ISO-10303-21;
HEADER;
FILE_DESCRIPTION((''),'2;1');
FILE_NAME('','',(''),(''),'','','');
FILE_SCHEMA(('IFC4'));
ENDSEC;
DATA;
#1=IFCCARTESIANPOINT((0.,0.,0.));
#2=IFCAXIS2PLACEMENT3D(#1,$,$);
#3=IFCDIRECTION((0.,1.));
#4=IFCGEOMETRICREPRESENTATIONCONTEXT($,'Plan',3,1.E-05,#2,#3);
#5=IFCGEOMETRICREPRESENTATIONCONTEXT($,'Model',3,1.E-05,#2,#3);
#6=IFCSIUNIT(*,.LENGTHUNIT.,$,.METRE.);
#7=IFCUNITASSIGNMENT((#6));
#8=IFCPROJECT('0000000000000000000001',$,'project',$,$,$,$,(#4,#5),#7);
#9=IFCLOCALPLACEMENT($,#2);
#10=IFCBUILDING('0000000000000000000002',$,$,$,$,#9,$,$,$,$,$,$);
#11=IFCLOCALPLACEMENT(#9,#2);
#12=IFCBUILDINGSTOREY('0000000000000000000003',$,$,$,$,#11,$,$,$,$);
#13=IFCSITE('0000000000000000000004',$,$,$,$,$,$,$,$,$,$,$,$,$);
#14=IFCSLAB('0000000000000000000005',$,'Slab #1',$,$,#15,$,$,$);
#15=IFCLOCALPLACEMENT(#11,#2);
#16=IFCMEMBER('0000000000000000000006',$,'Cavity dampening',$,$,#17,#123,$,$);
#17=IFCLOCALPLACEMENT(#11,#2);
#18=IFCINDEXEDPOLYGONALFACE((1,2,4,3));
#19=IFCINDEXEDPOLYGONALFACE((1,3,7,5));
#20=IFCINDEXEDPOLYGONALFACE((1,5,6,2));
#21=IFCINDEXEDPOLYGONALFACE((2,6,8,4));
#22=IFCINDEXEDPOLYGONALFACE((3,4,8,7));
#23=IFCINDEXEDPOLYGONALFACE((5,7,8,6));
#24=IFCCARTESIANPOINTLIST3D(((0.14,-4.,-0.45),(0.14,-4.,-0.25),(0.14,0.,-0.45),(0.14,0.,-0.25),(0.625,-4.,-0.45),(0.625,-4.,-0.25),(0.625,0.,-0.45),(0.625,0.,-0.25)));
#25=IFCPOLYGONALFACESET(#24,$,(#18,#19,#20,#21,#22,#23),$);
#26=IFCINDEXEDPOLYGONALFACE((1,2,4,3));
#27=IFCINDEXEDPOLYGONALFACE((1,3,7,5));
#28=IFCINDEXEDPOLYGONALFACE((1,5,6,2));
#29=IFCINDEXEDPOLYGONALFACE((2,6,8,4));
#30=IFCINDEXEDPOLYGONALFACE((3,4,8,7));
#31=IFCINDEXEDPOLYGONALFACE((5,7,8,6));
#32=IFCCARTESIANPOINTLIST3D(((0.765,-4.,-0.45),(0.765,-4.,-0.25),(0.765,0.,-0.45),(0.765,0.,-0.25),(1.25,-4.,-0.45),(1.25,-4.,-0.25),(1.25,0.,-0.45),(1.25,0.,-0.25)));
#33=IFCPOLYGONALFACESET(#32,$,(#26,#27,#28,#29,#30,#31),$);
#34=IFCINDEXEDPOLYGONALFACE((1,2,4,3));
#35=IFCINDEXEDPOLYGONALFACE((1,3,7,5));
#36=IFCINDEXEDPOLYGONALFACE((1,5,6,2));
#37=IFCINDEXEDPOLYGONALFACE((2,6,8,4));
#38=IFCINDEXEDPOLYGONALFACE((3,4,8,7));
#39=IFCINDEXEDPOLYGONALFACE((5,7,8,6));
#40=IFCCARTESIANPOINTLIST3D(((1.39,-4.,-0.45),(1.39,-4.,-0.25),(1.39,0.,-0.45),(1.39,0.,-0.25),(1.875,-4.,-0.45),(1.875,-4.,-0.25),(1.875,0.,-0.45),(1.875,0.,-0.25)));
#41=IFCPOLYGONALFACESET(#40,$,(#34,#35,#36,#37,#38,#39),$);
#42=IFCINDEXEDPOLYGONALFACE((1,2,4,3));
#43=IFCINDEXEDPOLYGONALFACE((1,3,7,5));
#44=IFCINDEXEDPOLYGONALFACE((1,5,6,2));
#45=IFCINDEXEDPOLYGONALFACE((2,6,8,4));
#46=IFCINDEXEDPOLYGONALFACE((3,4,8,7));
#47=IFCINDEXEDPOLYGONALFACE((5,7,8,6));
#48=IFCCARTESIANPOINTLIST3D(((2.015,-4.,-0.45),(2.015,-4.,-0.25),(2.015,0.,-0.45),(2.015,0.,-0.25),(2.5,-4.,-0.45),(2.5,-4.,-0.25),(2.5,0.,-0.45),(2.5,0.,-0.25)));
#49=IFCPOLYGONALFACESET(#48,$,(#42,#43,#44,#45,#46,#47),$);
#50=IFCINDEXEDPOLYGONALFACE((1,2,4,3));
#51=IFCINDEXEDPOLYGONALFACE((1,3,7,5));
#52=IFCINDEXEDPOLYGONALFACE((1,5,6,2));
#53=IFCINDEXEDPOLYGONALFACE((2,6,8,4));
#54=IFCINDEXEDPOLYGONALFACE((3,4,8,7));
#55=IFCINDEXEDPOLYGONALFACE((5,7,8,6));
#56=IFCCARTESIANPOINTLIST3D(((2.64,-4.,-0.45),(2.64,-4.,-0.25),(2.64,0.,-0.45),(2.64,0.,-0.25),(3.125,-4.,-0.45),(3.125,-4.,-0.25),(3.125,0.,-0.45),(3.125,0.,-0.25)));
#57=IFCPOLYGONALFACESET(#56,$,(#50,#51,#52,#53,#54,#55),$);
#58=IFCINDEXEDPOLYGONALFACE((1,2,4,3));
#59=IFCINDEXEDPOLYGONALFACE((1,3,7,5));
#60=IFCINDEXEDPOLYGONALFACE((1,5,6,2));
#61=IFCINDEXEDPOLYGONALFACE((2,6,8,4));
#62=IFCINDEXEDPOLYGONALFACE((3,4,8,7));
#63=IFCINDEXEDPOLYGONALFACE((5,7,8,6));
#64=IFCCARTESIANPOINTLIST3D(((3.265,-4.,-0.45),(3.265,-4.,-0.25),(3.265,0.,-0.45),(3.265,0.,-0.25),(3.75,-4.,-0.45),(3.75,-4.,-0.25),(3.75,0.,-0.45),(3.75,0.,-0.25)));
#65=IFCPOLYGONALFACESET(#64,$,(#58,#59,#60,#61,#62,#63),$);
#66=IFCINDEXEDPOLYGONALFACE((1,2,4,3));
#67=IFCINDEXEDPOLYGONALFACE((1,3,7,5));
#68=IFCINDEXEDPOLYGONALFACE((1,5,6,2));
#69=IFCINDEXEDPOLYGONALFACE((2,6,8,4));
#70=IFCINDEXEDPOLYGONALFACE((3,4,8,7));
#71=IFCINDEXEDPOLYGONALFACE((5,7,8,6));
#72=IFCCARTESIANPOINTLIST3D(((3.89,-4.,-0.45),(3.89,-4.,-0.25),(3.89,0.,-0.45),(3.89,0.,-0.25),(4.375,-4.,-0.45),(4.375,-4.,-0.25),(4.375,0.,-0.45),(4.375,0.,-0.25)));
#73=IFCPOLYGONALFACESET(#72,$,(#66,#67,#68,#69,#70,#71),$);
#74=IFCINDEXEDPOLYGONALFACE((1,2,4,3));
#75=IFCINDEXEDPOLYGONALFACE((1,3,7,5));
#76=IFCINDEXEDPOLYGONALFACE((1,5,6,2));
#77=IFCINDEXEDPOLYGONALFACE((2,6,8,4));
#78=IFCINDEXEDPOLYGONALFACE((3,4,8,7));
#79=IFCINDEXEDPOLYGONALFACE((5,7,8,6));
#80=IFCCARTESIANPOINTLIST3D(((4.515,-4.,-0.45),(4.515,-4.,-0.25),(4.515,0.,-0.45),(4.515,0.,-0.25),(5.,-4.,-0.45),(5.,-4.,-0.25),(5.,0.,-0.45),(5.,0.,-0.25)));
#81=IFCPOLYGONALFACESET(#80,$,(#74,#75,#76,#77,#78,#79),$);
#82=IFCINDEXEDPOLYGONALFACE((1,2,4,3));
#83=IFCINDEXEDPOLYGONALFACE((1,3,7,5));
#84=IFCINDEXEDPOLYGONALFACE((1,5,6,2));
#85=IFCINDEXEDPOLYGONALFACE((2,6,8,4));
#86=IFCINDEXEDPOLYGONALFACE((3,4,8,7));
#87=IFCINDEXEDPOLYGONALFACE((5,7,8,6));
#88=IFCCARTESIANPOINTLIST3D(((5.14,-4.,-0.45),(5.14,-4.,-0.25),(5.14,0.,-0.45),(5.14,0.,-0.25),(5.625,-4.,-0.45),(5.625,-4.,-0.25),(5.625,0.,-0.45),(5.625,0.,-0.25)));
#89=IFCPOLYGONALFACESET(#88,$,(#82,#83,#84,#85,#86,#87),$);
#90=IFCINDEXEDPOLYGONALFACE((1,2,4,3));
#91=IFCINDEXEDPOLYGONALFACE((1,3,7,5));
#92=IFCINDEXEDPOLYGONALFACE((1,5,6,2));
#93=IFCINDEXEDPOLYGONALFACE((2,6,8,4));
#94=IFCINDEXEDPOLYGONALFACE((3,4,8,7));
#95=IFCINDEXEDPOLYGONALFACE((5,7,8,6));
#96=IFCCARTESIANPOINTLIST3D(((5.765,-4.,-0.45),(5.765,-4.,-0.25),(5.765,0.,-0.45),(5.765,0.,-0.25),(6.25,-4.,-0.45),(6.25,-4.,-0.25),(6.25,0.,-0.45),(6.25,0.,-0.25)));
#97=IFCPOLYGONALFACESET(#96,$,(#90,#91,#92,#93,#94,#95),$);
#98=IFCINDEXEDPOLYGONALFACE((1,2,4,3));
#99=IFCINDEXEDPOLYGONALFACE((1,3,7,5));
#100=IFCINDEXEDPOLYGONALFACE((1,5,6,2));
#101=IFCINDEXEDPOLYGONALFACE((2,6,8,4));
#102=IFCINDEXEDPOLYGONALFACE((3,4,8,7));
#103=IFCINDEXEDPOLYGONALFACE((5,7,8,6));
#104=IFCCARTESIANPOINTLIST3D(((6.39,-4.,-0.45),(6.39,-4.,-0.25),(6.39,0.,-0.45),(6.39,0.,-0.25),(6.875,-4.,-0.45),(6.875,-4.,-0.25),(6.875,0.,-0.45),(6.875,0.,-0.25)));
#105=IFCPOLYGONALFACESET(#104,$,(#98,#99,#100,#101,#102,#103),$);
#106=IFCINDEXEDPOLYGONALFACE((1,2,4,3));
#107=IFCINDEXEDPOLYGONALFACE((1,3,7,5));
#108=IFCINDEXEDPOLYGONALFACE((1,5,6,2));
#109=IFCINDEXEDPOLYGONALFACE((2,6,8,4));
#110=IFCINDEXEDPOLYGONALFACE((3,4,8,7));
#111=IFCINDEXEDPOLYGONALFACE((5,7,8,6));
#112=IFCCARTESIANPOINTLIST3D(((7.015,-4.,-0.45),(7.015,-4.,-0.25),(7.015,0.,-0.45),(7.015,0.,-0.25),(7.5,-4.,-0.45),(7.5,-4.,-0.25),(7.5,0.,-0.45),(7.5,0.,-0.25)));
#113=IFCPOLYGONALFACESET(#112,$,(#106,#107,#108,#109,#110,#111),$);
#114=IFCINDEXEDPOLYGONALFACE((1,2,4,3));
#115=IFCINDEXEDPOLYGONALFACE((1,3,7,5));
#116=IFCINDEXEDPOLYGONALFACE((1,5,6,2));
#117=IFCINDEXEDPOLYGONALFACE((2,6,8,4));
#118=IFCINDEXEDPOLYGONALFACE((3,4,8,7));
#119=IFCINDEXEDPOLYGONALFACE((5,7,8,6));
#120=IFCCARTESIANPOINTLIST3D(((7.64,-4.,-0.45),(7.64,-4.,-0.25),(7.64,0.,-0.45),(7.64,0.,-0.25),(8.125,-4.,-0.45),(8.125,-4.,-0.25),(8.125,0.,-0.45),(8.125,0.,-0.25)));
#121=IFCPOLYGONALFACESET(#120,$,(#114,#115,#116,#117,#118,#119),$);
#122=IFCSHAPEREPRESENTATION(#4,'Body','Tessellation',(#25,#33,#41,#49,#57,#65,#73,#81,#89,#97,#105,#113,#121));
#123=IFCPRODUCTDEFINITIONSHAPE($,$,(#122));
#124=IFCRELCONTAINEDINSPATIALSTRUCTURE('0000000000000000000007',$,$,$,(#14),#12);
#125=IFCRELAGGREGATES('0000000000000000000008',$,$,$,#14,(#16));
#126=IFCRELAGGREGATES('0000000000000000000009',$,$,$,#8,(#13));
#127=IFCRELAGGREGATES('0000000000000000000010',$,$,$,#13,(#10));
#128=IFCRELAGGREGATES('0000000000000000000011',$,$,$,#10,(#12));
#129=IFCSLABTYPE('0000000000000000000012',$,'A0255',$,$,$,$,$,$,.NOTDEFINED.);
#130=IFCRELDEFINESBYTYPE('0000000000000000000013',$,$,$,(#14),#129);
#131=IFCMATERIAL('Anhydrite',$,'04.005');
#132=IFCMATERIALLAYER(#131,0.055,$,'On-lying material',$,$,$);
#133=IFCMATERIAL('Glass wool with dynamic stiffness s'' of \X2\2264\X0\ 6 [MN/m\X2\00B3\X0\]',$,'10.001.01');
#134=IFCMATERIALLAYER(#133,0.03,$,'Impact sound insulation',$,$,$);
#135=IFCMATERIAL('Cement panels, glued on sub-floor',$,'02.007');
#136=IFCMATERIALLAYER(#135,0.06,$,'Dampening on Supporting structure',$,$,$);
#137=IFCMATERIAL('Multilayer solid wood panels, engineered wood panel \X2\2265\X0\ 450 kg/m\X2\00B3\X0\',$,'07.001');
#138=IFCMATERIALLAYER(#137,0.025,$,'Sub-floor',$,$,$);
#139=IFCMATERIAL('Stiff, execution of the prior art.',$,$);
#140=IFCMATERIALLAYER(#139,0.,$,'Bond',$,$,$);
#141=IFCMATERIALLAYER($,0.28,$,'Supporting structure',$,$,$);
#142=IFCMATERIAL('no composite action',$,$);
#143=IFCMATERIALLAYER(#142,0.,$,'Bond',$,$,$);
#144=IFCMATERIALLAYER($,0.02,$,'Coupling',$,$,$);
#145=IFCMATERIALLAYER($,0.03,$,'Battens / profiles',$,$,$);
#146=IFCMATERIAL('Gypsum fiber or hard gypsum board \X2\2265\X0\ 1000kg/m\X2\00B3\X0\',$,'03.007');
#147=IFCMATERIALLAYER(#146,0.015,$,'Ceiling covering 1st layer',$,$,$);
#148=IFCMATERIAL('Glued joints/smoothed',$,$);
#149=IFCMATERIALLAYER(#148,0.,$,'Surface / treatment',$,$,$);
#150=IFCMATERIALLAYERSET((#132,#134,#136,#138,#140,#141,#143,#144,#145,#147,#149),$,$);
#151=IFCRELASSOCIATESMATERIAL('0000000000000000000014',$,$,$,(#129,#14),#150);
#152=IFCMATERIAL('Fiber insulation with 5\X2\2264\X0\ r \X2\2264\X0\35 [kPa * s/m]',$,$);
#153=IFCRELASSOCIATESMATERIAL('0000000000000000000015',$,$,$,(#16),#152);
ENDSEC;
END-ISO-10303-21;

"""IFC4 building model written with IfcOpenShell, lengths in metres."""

from ifc_helpers import new_model, si_unit, direction, frame, frame_2d, origin, place, context, project, spatial, rectangle, extrude, material, layer, layer_set, type_object, element, aggregate, save


model = new_model("IFC4")

# Units and contexts
plan_context = context("Plan", 3, precision=1e-05, world=origin(), true_north=direction((0.0, 1.0)))
model_context = context("Model", 3, precision=1e-05, world=origin(), true_north=direction((0.0, 1.0)))
ifc_project = project(units=[si_unit("LENGTHUNIT", "METRE")], contexts=[plan_context, model_context])

# Site, building, storey
site = spatial("IfcSite", under=ifc_project)
building_placement = place(None, origin())
building = spatial("IfcBuilding", under=site, at=building_placement)
storey_placement = place(building_placement, origin())
storey = spatial("IfcBuildingStorey", under=building, at=storey_placement)

# Slab, member
ifc_material_1 = material(Name="Anhydrite", Category="04.005")
ifc_layer_1 = layer(ifc_material_1, 0.055, Name="On-lying material")
ifc_material_2 = material(Name="Glass wool with dynamic stiffness s' of ≤ 6 [MN/m³]", Category="10.001.01")
ifc_layer_2 = layer(ifc_material_2, 0.03, Name="Impact sound insulation")
ifc_material_3 = material(Name="Cement panels, glued on sub-floor", Category="02.007")
ifc_layer_3 = layer(ifc_material_3, 0.06, Name="Dampening on Supporting structure")
ifc_material_4 = material(Name="Multilayer solid wood panels, engineered wood panel ≥ 450 kg/m³", Category="07.001")
ifc_layer_4 = layer(ifc_material_4, 0.025, Name="Sub-floor")
ifc_material_5 = material(Name="Stiff, execution of the prior art.")
ifc_layer_5 = layer(ifc_material_5, 0.0, Name="Bond")
ifc_layer_6 = layer(None, 0.28, Name="Supporting structure")
ifc_material_6 = material(Name="no composite action")
ifc_layer_7 = layer(ifc_material_6, 0.0, Name="Bond")
ifc_layer_8 = layer(None, 0.02, Name="Coupling")
ifc_layer_9 = layer(None, 0.03, Name="Battens / profiles")
ifc_material_7 = material(Name="Gypsum fiber or hard gypsum board ≥ 1000kg/m³", Category="03.007")
ifc_layer_10 = layer(ifc_material_7, 0.015, Name="Ceiling covering 1st layer")
ifc_material_8 = material(Name="Glued joints/smoothed")
ifc_layer_11 = layer(ifc_material_8, 0.0, Name="Surface / treatment")
ifc_layer_set = layer_set([ifc_layer_1, ifc_layer_2, ifc_layer_3, ifc_layer_4, ifc_layer_5, ifc_layer_6, ifc_layer_7, ifc_layer_8, ifc_layer_9, ifc_layer_10, ifc_layer_11])
slab_type = type_object("IfcSlabType", Name="A0255", PredefinedType="NOTDEFINED", material=ifc_layer_set)
slab_placement = place(None, frame((0.0, 0.0, 0.0), z_axis=(0.0, 0.0, -1.0), x_axis=(1.0, 0.0, 0.0)))
slab = element("IfcSlab", 1, at=slab_placement, inside=storey, type_object=slab_type, material=ifc_layer_set, Name="Slab #1")
ifc_material_9 = material(Name="Fiber insulation with 5≤ r ≤35 [kPa * s/m]")
member_1_placement = place(slab_placement, origin())
member_1 = element("IfcMember", 2, at=member_1_placement, material=ifc_material_9, Name="Cavity dampening", context=plan_context, shape_type="SweptSolid", body=[
    extrude(rectangle(XDim=0.485, YDim=0.2, at=frame_2d((0.2425, 0.1), x_axis=(1.0, 0.0))), frame((0.14, 4.0, 0.25), z_axis=(0.0, -1.0, 0.0), x_axis=(1.0, 0.0, 0.0)), (0.0, 0.0, 1.0), 4.0),
    extrude(rectangle(XDim=0.485, YDim=0.2, at=frame_2d((0.2425, 0.1), x_axis=(1.0, 0.0))), frame((0.765, 4.0, 0.25), z_axis=(0.0, -1.0, 0.0), x_axis=(1.0, 0.0, 0.0)), (0.0, 0.0, 1.0), 4.0),
    extrude(rectangle(XDim=0.485, YDim=0.2, at=frame_2d((0.2425, 0.1), x_axis=(1.0, 0.0))), frame((1.39, 4.0, 0.25), z_axis=(0.0, -1.0, 0.0), x_axis=(1.0, 0.0, 0.0)), (0.0, 0.0, 1.0), 4.0),
    extrude(rectangle(XDim=0.485, YDim=0.2, at=frame_2d((0.2425, 0.1), x_axis=(1.0, 0.0))), frame((2.015, 4.0, 0.25), z_axis=(0.0, -1.0, 0.0), x_axis=(1.0, 0.0, 0.0)), (0.0, 0.0, 1.0), 4.0),
    extrude(rectangle(XDim=0.485, YDim=0.2, at=frame_2d((0.2425, 0.1), x_axis=(1.0, 0.0))), frame((2.64, 4.0, 0.25), z_axis=(0.0, -1.0, 0.0), x_axis=(1.0, 0.0, 0.0)), (0.0, 0.0, 1.0), 4.0),
    extrude(rectangle(XDim=0.485, YDim=0.2, at=frame_2d((0.2425, 0.1), x_axis=(1.0, 0.0))), frame((3.265, 4.0, 0.25), z_axis=(0.0, -1.0, 0.0), x_axis=(1.0, 0.0, 0.0)), (0.0, 0.0, 1.0), 4.0),
    extrude(rectangle(XDim=0.485, YDim=0.2, at=frame_2d((0.2425, 0.1), x_axis=(1.0, 0.0))), frame((3.89, 4.0, 0.25), z_axis=(0.0, -1.0, 0.0), x_axis=(1.0, 0.0, 0.0)), (0.0, 0.0, 1.0), 4.0),
    extrude(rectangle(XDim=0.485, YDim=0.2, at=frame_2d((0.2425, 0.1), x_axis=(1.0, 0.0))), frame((4.515, 4.0, 0.25), z_axis=(0.0, -1.0, 0.0), x_axis=(1.0, 0.0, 0.0)), (0.0, 0.0, 1.0), 4.0),
    extrude(rectangle(XDim=0.485, YDim=0.2, at=frame_2d((0.2425, 0.1), x_axis=(1.0, 0.0))), frame((5.14, 4.0, 0.25), z_axis=(0.0, -1.0, 0.0), x_axis=(1.0, 0.0, 0.0)), (0.0, 0.0, 1.0), 4.0),
    extrude(rectangle(XDim=0.485, YDim=0.2, at=frame_2d((0.2425, 0.1), x_axis=(1.0, 0.0))), frame((5.765, 4.0, 0.25), z_axis=(0.0, -1.0, 0.0), x_axis=(1.0, 0.0, 0.0)), (0.0, 0.0, 1.0), 4.0),
    extrude(rectangle(XDim=0.485, YDim=0.2, at=frame_2d((0.2425, 0.1), x_axis=(1.0, 0.0))), frame((6.39, 4.0, 0.25), z_axis=(0.0, -1.0, 0.0), x_axis=(1.0, 0.0, 0.0)), (0.0, 0.0, 1.0), 4.0),
    extrude(rectangle(XDim=0.485, YDim=0.2, at=frame_2d((0.2425, 0.1), x_axis=(1.0, 0.0))), frame((7.015, 4.0, 0.25), z_axis=(0.0, -1.0, 0.0), x_axis=(1.0, 0.0, 0.0)), (0.0, 0.0, 1.0), 4.0),
    extrude(rectangle(XDim=0.485, YDim=0.2, at=frame_2d((0.2425, 0.1), x_axis=(1.0, 0.0))), frame((7.64, 4.0, 0.25), z_axis=(0.0, -1.0, 0.0), x_axis=(1.0, 0.0, 0.0)), (0.0, 0.0, 1.0), 4.0),
])
aggregate(slab, [member_1])

save(model, "model.ifc")
